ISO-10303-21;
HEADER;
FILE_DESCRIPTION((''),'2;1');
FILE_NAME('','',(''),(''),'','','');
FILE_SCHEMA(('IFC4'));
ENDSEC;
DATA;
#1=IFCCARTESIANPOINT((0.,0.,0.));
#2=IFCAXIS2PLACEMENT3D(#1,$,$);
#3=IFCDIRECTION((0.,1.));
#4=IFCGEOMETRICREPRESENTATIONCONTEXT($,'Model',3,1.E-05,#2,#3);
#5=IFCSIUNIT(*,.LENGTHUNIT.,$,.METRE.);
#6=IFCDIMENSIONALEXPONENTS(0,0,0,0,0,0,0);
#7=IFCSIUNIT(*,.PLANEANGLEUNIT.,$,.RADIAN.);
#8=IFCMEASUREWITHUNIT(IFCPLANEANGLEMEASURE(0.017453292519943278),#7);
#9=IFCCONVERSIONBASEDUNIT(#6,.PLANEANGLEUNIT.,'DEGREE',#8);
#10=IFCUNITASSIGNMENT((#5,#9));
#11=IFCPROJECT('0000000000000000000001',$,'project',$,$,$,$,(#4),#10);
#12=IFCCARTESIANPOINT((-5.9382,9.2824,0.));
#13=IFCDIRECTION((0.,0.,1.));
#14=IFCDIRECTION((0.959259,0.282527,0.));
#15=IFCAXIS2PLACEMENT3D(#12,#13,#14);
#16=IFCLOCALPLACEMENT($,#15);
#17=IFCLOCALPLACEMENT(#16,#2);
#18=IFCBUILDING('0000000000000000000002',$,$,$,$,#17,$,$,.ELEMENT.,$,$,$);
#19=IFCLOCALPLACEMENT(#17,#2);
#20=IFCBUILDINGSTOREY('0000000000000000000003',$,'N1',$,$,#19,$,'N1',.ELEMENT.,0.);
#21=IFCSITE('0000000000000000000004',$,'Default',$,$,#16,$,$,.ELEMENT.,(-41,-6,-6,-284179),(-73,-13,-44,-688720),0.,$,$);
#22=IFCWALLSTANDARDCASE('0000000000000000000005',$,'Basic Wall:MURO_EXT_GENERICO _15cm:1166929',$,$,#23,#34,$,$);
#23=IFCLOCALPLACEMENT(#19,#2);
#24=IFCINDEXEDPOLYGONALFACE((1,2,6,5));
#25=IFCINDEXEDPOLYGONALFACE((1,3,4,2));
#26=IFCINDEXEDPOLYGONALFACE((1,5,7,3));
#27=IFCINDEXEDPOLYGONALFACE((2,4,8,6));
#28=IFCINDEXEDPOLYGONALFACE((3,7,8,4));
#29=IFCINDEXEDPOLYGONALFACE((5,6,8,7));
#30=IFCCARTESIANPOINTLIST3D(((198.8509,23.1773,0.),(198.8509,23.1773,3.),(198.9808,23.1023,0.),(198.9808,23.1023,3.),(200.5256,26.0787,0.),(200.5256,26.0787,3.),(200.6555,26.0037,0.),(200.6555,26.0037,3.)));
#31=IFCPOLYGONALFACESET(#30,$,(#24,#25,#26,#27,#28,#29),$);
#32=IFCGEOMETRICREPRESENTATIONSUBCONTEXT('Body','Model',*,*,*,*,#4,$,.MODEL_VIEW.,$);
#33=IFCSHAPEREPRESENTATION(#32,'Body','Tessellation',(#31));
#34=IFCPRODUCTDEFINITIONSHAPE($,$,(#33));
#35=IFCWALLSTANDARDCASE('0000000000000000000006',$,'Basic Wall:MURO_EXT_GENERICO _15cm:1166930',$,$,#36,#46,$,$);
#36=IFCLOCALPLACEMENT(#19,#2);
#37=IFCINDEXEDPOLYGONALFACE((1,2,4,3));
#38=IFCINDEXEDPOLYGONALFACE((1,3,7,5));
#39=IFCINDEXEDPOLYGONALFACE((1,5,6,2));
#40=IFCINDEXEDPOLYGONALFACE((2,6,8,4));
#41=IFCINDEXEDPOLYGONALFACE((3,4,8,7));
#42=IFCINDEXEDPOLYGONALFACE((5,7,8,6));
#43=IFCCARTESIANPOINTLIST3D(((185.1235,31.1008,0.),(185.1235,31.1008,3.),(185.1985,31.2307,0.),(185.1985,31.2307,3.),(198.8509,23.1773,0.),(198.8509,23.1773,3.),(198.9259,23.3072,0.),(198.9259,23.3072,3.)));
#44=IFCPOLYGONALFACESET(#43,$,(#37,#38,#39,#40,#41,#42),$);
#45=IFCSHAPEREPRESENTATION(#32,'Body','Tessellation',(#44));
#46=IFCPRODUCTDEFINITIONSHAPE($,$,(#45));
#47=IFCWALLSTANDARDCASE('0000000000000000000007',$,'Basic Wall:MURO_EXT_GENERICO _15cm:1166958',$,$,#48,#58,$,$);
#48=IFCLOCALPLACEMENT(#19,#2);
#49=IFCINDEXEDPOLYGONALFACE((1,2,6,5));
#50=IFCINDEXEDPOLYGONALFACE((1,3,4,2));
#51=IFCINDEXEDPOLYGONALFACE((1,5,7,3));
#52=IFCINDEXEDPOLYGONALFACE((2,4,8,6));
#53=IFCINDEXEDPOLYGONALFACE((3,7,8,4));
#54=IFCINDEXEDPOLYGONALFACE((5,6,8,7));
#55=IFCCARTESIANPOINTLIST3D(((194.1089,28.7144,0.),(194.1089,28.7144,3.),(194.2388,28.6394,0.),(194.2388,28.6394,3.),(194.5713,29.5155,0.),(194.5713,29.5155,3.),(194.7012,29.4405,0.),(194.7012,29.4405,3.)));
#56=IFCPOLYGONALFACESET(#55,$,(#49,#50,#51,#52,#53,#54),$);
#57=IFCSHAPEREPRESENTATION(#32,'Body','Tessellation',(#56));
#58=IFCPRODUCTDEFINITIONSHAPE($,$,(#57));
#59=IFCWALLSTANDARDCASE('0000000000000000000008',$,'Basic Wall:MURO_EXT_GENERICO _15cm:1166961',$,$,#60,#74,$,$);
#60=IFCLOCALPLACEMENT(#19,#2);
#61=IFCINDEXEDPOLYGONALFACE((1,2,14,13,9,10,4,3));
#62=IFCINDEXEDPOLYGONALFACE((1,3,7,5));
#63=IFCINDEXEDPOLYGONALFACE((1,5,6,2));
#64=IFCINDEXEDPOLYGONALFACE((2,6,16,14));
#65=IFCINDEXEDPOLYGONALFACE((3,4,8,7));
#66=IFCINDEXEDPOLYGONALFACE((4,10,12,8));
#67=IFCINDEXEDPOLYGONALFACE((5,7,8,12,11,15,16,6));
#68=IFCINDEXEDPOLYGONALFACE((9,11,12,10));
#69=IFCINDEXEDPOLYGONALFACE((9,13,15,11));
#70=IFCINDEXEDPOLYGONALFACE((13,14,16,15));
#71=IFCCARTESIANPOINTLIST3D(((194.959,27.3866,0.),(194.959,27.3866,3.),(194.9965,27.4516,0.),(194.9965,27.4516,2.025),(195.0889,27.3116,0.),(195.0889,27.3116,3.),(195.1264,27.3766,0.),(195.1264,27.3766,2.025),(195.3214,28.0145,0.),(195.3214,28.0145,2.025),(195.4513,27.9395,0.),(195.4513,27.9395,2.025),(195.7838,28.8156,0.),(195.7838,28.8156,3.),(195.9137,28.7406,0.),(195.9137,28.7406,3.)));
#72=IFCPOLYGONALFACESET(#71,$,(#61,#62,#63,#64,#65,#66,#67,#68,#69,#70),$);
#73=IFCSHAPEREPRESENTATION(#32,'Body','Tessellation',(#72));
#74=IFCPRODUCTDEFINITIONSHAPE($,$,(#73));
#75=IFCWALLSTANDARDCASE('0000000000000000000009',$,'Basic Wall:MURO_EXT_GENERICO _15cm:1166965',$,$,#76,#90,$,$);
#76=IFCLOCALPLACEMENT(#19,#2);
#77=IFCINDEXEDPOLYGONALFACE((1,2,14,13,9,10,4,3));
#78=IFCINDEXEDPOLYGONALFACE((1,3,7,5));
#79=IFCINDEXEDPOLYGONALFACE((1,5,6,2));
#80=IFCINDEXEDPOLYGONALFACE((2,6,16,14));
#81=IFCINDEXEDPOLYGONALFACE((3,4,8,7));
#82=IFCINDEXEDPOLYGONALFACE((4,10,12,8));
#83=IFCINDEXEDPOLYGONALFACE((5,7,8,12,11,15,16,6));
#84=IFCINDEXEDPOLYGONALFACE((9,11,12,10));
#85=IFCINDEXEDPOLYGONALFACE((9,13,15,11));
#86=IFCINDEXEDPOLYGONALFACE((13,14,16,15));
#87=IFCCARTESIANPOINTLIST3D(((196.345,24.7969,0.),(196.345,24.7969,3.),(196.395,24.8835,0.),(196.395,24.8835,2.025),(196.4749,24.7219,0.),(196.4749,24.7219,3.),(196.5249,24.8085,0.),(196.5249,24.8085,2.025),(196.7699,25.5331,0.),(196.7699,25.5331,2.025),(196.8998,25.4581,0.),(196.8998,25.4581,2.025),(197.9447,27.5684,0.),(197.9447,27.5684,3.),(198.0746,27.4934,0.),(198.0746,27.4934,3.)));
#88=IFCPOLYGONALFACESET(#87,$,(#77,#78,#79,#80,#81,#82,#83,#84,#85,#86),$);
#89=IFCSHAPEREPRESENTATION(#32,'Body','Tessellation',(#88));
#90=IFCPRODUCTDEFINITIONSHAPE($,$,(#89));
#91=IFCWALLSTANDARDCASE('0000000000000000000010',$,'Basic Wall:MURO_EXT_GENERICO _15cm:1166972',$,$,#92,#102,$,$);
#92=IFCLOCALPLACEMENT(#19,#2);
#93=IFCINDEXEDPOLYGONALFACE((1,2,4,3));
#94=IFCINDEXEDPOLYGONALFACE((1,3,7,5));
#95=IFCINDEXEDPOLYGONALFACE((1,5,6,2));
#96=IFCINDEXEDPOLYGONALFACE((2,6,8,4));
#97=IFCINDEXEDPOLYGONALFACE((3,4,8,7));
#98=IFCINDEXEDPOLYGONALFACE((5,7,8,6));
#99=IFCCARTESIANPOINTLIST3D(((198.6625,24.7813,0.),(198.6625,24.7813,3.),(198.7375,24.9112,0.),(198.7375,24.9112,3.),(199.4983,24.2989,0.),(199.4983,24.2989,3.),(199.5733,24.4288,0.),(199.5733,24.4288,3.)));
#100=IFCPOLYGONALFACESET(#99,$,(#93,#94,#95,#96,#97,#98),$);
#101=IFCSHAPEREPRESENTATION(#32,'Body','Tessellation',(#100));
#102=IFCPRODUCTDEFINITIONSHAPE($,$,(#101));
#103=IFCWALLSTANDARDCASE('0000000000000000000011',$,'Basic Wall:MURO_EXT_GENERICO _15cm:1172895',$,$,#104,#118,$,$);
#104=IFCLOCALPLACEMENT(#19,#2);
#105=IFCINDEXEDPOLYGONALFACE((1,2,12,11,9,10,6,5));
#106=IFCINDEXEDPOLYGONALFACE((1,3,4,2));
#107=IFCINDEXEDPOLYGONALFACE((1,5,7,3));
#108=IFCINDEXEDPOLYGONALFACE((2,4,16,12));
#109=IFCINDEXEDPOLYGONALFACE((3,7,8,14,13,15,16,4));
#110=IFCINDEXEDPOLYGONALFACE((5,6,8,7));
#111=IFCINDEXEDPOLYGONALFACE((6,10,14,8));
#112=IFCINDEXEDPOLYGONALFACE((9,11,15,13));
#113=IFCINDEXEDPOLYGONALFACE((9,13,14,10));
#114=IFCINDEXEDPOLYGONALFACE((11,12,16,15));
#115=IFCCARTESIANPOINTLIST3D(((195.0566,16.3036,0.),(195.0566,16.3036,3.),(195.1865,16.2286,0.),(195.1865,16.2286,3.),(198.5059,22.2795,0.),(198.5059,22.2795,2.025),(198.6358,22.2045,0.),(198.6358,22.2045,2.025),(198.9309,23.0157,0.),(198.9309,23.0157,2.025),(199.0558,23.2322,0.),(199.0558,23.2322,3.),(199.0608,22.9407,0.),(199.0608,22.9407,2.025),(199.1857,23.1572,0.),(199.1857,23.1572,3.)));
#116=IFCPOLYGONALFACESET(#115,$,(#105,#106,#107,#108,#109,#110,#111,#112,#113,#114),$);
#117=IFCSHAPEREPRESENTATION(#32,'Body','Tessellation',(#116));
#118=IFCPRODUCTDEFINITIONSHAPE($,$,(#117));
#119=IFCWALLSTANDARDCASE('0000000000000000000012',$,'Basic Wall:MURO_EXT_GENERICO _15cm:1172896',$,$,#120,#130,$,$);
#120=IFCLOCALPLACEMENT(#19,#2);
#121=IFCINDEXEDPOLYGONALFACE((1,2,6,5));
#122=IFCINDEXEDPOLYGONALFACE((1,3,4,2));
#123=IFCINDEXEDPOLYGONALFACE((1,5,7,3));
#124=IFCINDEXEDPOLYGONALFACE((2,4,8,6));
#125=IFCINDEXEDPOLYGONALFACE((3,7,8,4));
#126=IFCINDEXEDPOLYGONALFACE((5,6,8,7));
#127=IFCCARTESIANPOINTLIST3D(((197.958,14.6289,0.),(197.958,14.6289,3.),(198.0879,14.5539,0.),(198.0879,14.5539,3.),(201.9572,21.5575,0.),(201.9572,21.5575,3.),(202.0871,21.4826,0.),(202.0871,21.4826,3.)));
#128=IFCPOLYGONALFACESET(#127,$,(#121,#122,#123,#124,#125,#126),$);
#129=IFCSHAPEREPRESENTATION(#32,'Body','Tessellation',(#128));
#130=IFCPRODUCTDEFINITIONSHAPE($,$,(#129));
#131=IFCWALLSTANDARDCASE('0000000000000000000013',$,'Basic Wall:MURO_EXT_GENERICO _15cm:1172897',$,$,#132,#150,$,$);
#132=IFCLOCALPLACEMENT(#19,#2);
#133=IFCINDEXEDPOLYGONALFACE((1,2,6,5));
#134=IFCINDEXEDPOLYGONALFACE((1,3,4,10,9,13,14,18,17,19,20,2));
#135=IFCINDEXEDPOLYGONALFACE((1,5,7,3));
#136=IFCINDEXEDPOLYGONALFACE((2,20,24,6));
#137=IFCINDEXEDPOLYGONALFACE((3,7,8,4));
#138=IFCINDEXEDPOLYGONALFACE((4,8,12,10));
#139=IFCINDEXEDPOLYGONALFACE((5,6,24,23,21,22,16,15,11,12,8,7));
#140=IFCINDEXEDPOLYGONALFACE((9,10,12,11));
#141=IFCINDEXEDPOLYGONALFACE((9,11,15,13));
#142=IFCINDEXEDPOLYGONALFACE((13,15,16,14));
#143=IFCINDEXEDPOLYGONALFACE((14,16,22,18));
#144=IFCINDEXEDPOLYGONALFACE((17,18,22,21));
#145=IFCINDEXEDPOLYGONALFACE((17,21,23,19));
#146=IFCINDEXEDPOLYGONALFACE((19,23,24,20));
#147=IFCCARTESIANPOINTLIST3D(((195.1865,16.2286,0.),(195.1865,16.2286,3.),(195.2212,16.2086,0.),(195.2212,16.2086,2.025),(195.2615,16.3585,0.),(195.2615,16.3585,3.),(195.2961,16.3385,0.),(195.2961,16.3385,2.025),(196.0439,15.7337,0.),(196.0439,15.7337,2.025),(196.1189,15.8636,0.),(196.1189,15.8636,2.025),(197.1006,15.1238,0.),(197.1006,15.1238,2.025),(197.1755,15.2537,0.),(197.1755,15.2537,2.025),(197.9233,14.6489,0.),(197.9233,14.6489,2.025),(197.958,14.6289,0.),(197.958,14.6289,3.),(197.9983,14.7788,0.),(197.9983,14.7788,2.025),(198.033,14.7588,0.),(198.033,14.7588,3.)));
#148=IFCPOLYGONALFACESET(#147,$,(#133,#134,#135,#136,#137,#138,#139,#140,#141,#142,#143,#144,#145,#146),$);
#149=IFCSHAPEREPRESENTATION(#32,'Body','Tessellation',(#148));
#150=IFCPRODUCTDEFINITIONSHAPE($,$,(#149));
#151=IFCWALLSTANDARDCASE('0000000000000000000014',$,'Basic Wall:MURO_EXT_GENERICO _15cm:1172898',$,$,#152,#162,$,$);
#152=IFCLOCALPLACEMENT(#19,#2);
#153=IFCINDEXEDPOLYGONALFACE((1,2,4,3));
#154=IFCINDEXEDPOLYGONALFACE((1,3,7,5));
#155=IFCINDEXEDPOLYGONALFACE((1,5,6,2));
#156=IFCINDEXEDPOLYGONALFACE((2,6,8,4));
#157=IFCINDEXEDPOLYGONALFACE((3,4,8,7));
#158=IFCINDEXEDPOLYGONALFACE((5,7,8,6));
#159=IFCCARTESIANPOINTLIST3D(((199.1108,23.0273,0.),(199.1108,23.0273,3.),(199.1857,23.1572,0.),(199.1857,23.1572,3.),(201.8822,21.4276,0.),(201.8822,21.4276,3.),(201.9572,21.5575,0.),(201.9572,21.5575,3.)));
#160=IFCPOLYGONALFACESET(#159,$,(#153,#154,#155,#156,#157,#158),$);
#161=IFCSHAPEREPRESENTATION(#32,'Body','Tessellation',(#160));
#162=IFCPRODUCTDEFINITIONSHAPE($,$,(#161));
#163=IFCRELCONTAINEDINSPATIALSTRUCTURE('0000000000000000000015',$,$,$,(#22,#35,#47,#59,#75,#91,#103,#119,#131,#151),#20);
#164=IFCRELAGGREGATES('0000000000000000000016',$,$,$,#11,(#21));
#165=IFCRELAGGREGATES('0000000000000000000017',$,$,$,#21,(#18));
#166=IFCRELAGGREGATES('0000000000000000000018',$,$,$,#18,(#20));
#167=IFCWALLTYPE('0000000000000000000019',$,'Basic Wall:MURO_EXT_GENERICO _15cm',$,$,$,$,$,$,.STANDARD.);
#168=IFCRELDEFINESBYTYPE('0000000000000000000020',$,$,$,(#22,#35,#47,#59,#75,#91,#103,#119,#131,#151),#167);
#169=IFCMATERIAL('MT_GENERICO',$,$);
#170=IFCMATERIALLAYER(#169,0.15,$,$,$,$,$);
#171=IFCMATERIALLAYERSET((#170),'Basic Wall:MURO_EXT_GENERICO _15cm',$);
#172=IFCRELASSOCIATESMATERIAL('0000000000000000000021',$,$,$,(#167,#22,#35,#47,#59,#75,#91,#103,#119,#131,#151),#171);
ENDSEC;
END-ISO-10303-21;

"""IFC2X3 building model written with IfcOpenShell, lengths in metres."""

from ifc_helpers import new_model, entity, si_unit, converted_unit, direction, frame, frame_2d, origin, place, context, subcontext, project, spatial, rectangle, extrude, material, layer, layer_set, layer_usage, type_object, element, save


model = new_model("IFC2X3")

# Units and contexts
model_context = context("Model", 3, precision=1e-05, world=origin(), true_north=direction((0.0, 1.0)))
body_context = subcontext(model_context, "Body", "Model", "MODEL_VIEW")
ifc_project = project(units=[si_unit("LENGTHUNIT", "METRE"), converted_unit("PLANEANGLEUNIT", "DEGREE", entity("IfcPlaneAngleMeasure", 0.017453292519943278), si_unit("PLANEANGLEUNIT", "RADIAN"), dimensions=[0, 0, 0, 0, 0, 0, 0])], contexts=[model_context])

# Site, building, storey
site_placement = place(None, frame((-5.9382, 9.2824, 0.0), z_axis=(0.0, 0.0, 1.0), x_axis=(0.959259, 0.282527, 0.0)))
site = spatial("IfcSite", under=ifc_project, at=site_placement, Name="Default", CompositionType="ELEMENT", RefLatitude=(-41, -6, -6, -284179), RefLongitude=(-73, -13, -44, -688720), RefElevation=0.0)
building_placement = place(site_placement, origin())
building = spatial("IfcBuilding", under=site, at=building_placement, CompositionType="ELEMENT")
storey_placement = place(building_placement, origin())
storey = spatial("IfcBuildingStorey", under=building, at=storey_placement, Name="N1", LongName="N1", CompositionType="ELEMENT", Elevation=0.0)

# Walls
ifc_material_1 = material(Name="MT_GENERICO")
ifc_layer_1 = layer(ifc_material_1, 0.15)
ifc_layer_set_1 = layer_set([ifc_layer_1], Name="Basic Wall:MURO_EXT_GENERICO _15cm")
ifc_layer_usage_1 = layer_usage(ifc_layer_set_1, "AXIS2", "NEGATIVE", 0.075)
wall_type_1 = type_object("IfcWallType", Name="Basic Wall:MURO_EXT_GENERICO _15cm", PredefinedType="STANDARD", material=ifc_layer_set_1)
wall_1_placement = place(storey_placement, frame((200.5906, 26.0412, 0.0), z_axis=(0.0, 0.0, 1.0), x_axis=(-0.499903, -0.866082, 0.0)))
element("IfcWallStandardCase", 1, at=wall_1_placement, inside=storey, type_object=wall_type_1, material=ifc_layer_usage_1, Name="Basic Wall:MURO_EXT_GENERICO _15cm:1166929", context=body_context, shape_type="SweptSolid", body=[
    extrude(rectangle(XDim=3.35, YDim=0.15, at=frame_2d((1.675, 0.0), x_axis=(-1.0, 0.0))), origin(), (0.0, 0.0, 1.0), 3.0),
])
ifc_layer_usage_2 = layer_usage(ifc_layer_set_1, "AXIS2", "NEGATIVE", 0.075)
wall_2_placement = place(storey_placement, frame((198.8884, 23.2422, 0.0), z_axis=(0.0, 0.0, 1.0), x_axis=(-0.866082, 0.499903, 0.0)))
element("IfcWallStandardCase", 2, at=wall_2_placement, inside=storey, type_object=wall_type_1, material=ifc_layer_usage_2, Name="Basic Wall:MURO_EXT_GENERICO _15cm:1166930", context=body_context, shape_type="SweptSolid", body=[
    extrude(rectangle(XDim=15.85, YDim=0.15, at=frame_2d((7.925, 0.0), x_axis=(-1.0, 0.0))), origin(), (0.0, 0.0, 1.0), 3.0),
])

# Wall
ifc_layer_usage_3 = layer_usage(ifc_layer_set_1, "AXIS2", "NEGATIVE", 0.075)
wall_3_placement = place(storey_placement, frame((194.6363, 29.478, 0.0), z_axis=(0.0, 0.0, 1.0), x_axis=(-0.499903, -0.866082, 0.0)))
element("IfcWallStandardCase", 3, at=wall_3_placement, inside=storey, type_object=wall_type_1, material=ifc_layer_usage_3, Name="Basic Wall:MURO_EXT_GENERICO _15cm:1166958", context=body_context, shape_type="SweptSolid", body=[
    extrude(rectangle(XDim=0.925, YDim=0.15, at=frame_2d((0.4625, 0.0), x_axis=(-1.0, 0.0))), origin(), (0.0, 0.0, 1.0), 3.0),
])

# Walls, openings
ifc_layer_usage_4 = layer_usage(ifc_layer_set_1, "AXIS2", "NEGATIVE", 0.075)
wall_4_placement = place(storey_placement, frame((195.8488, 28.7781, 0.0), z_axis=(0.0, 0.0, 1.0), x_axis=(-0.499903, -0.866082, 0.0)))
wall_4 = element("IfcWallStandardCase", 4, at=wall_4_placement, inside=storey, type_object=wall_type_1, material=ifc_layer_usage_4, Name="Basic Wall:MURO_EXT_GENERICO _15cm:1166961", context=body_context, shape_type="SweptSolid", body=[
    extrude(rectangle(XDim=1.65, YDim=0.15, at=frame_2d((0.825, 0.0), x_axis=(-1.0, 0.0))), origin(), (0.0, 0.0, 1.0), 3.0),
])
opening_1_placement = place(wall_4_placement, frame((1.575, 0.075, 0.0)))
element("IfcOpeningElement", 5, at=opening_1_placement, cuts=wall_4, ObjectType="Opening", context=body_context, shape_type="SweptSolid", body=[
    extrude(rectangle(XDim=2.025, YDim=0.65, at=frame_2d((1.0125, 0.325), x_axis=(1.0, 0.0))), frame((0.0, 0.0, 0.0), z_axis=(0.0, -1.0, 0.0), x_axis=(0.0, 0.0, 1.0)), (0.0, 0.0, 1.0), 0.15),
])
ifc_layer_usage_5 = layer_usage(ifc_layer_set_1, "AXIS2", "NEGATIVE", 0.075)
wall_5_placement = place(storey_placement, frame((198.0096, 27.5309, 0.0), z_axis=(0.0, 0.0, 1.0), x_axis=(-0.499903, -0.866082, 0.0)))
wall_5 = element("IfcWallStandardCase", 6, at=wall_5_placement, inside=storey, type_object=wall_type_1, material=ifc_layer_usage_5, Name="Basic Wall:MURO_EXT_GENERICO _15cm:1166965", context=body_context, shape_type="SweptSolid", body=[
    extrude(rectangle(XDim=3.2, YDim=0.15, at=frame_2d((1.6, 0.0), x_axis=(-1.0, 0.0))), origin(), (0.0, 0.0, 1.0), 3.0),
])
opening_2_placement = place(wall_5_placement, frame((2.35, -0.075, 0.0)))
element("IfcOpeningElement", 7, at=opening_2_placement, cuts=wall_5, ObjectType="Opening", context=body_context, shape_type="SweptSolid", body=[
    extrude(rectangle(XDim=2.025, YDim=0.75, at=frame_2d((1.0125, 0.375), x_axis=(1.0, 0.0))), frame((0.0, 0.0, 0.0), z_axis=(0.0, 1.0, 0.0), x_axis=(0.0, 0.0, 1.0)), (0.0, 0.0, 1.0), 0.15),
])

# Wall
ifc_layer_usage_6 = layer_usage(ifc_layer_set_1, "AXIS2", "NEGATIVE", 0.075)
wall_6_placement = place(storey_placement, frame((199.5358, 24.3638, 0.0), z_axis=(0.0, 0.0, 1.0), x_axis=(-0.866082, 0.499903, 0.0)))
element("IfcWallStandardCase", 8, at=wall_6_placement, inside=storey, type_object=wall_type_1, material=ifc_layer_usage_6, Name="Basic Wall:MURO_EXT_GENERICO _15cm:1166972", context=body_context, shape_type="SweptSolid", body=[
    extrude(rectangle(XDim=0.965, YDim=0.15, at=frame_2d((0.4825, 0.0), x_axis=(-1.0, 0.0))), origin(), (0.0, 0.0, 1.0), 3.0),
])

# Wall, opening
ifc_layer_usage_7 = layer_usage(ifc_layer_set_1, "AXIS2", "NEGATIVE", 0.075)
wall_7_placement = place(storey_placement, frame((199.1208, 23.1947, 0.0), z_axis=(0.0, 0.0, 1.0), x_axis=(-0.499903, -0.866082, 0.0)))
wall_7 = element("IfcWallStandardCase", 9, at=wall_7_placement, inside=storey, type_object=wall_type_1, material=ifc_layer_usage_7, Name="Basic Wall:MURO_EXT_GENERICO _15cm:1172895", context=body_context, shape_type="SweptSolid", body=[
    extrude(rectangle(XDim=8.0, YDim=0.15, at=frame_2d((4.0, 0.0), x_axis=(-1.0, 0.0))), origin(), (0.0, 0.0, 1.0), 3.0),
])
opening_3_placement = place(wall_7_placement, frame((0.25, -0.075, 0.0)))
element("IfcOpeningElement", 10, at=opening_3_placement, cuts=wall_7, ObjectType="Opening", context=body_context, shape_type="SweptSolid", body=[
    extrude(rectangle(XDim=2.025, YDim=0.85, at=frame_2d((1.0125, 0.425), x_axis=(1.0, 0.0))), frame((0.0, 0.0, 0.0), z_axis=(0.0, 1.0, 0.0), x_axis=(0.0, 0.0, 1.0)), (0.0, 0.0, 1.0), 0.15),
])

# Wall
ifc_layer_usage_8 = layer_usage(ifc_layer_set_1, "AXIS2", "NEGATIVE", 0.075)
wall_8_placement = place(storey_placement, frame((198.0229, 14.5914, 0.0), z_axis=(0.0, 0.0, 1.0), x_axis=(0.499903, 0.866082, 0.0)))
element("IfcWallStandardCase", 11, at=wall_8_placement, inside=storey, type_object=wall_type_1, material=ifc_layer_usage_8, Name="Basic Wall:MURO_EXT_GENERICO _15cm:1172896", context=body_context, shape_type="SweptSolid", body=[
    extrude(rectangle(XDim=8.0, YDim=0.15, at=frame_2d((4.0, 0.0), x_axis=(-1.0, 0.0))), origin(), (0.0, 0.0, 1.0), 3.0),
])

# Wall, openings
ifc_layer_usage_9 = layer_usage(ifc_layer_set_1, "AXIS2", "NEGATIVE", 0.075)
wall_9_placement = place(storey_placement, frame((195.224, 16.2935, 0.0), z_axis=(0.0, 0.0, 1.0), x_axis=(0.866082, -0.499903, 0.0)))
wall_9 = element("IfcWallStandardCase", 12, at=wall_9_placement, inside=storey, type_object=wall_type_1, material=ifc_layer_usage_9, Name="Basic Wall:MURO_EXT_GENERICO _15cm:1172897", context=body_context, shape_type="SweptSolid", body=[
    extrude(rectangle(XDim=3.2, YDim=0.15, at=frame_2d((1.6, 0.0), x_axis=(1.0, 0.0))), origin(), (0.0, 0.0, 1.0), 3.0),
])
opening_4_placement = place(wall_9_placement, frame((2.21, -0.075, 0.0)))
element("IfcOpeningElement", 13, at=opening_4_placement, cuts=wall_9, ObjectType="Opening", context=body_context, shape_type="SweptSolid", body=[
    extrude(rectangle(XDim=2.025, YDim=0.95, at=frame_2d((1.0125, 0.475), x_axis=(1.0, 0.0))), frame((0.0, 0.0, 0.0), z_axis=(0.0, 1.0, 0.0), x_axis=(0.0, 0.0, 1.0)), (0.0, 0.0, 1.0), 0.15),
])
opening_5_placement = place(wall_9_placement, frame((0.04, -0.075, 0.0)))
element("IfcOpeningElement", 14, at=opening_5_placement, cuts=wall_9, ObjectType="Opening", context=body_context, shape_type="SweptSolid", body=[
    extrude(rectangle(XDim=2.025, YDim=0.95, at=frame_2d((1.0125, 0.475), x_axis=(1.0, 0.0))), frame((0.0, 0.0, 0.0), z_axis=(0.0, 1.0, 0.0), x_axis=(0.0, 0.0, 1.0)), (0.0, 0.0, 1.0), 0.15),
])

# Wall
ifc_layer_usage_10 = layer_usage(ifc_layer_set_1, "AXIS2", "NEGATIVE", 0.075)
wall_10_placement = place(storey_placement, frame((201.9197, 21.4926, 0.0), z_axis=(0.0, 0.0, 1.0), x_axis=(-0.866082, 0.499903, 0.0)))
element("IfcWallStandardCase", 15, at=wall_10_placement, inside=storey, type_object=wall_type_1, material=ifc_layer_usage_10, Name="Basic Wall:MURO_EXT_GENERICO _15cm:1172898", context=body_context, shape_type="SweptSolid", body=[
    extrude(rectangle(XDim=3.2, YDim=0.15, at=frame_2d((1.6, 0.0), x_axis=(-1.0, 0.0))), origin(), (0.0, 0.0, 1.0), 3.0),
])

save(model, "model.ifc")
